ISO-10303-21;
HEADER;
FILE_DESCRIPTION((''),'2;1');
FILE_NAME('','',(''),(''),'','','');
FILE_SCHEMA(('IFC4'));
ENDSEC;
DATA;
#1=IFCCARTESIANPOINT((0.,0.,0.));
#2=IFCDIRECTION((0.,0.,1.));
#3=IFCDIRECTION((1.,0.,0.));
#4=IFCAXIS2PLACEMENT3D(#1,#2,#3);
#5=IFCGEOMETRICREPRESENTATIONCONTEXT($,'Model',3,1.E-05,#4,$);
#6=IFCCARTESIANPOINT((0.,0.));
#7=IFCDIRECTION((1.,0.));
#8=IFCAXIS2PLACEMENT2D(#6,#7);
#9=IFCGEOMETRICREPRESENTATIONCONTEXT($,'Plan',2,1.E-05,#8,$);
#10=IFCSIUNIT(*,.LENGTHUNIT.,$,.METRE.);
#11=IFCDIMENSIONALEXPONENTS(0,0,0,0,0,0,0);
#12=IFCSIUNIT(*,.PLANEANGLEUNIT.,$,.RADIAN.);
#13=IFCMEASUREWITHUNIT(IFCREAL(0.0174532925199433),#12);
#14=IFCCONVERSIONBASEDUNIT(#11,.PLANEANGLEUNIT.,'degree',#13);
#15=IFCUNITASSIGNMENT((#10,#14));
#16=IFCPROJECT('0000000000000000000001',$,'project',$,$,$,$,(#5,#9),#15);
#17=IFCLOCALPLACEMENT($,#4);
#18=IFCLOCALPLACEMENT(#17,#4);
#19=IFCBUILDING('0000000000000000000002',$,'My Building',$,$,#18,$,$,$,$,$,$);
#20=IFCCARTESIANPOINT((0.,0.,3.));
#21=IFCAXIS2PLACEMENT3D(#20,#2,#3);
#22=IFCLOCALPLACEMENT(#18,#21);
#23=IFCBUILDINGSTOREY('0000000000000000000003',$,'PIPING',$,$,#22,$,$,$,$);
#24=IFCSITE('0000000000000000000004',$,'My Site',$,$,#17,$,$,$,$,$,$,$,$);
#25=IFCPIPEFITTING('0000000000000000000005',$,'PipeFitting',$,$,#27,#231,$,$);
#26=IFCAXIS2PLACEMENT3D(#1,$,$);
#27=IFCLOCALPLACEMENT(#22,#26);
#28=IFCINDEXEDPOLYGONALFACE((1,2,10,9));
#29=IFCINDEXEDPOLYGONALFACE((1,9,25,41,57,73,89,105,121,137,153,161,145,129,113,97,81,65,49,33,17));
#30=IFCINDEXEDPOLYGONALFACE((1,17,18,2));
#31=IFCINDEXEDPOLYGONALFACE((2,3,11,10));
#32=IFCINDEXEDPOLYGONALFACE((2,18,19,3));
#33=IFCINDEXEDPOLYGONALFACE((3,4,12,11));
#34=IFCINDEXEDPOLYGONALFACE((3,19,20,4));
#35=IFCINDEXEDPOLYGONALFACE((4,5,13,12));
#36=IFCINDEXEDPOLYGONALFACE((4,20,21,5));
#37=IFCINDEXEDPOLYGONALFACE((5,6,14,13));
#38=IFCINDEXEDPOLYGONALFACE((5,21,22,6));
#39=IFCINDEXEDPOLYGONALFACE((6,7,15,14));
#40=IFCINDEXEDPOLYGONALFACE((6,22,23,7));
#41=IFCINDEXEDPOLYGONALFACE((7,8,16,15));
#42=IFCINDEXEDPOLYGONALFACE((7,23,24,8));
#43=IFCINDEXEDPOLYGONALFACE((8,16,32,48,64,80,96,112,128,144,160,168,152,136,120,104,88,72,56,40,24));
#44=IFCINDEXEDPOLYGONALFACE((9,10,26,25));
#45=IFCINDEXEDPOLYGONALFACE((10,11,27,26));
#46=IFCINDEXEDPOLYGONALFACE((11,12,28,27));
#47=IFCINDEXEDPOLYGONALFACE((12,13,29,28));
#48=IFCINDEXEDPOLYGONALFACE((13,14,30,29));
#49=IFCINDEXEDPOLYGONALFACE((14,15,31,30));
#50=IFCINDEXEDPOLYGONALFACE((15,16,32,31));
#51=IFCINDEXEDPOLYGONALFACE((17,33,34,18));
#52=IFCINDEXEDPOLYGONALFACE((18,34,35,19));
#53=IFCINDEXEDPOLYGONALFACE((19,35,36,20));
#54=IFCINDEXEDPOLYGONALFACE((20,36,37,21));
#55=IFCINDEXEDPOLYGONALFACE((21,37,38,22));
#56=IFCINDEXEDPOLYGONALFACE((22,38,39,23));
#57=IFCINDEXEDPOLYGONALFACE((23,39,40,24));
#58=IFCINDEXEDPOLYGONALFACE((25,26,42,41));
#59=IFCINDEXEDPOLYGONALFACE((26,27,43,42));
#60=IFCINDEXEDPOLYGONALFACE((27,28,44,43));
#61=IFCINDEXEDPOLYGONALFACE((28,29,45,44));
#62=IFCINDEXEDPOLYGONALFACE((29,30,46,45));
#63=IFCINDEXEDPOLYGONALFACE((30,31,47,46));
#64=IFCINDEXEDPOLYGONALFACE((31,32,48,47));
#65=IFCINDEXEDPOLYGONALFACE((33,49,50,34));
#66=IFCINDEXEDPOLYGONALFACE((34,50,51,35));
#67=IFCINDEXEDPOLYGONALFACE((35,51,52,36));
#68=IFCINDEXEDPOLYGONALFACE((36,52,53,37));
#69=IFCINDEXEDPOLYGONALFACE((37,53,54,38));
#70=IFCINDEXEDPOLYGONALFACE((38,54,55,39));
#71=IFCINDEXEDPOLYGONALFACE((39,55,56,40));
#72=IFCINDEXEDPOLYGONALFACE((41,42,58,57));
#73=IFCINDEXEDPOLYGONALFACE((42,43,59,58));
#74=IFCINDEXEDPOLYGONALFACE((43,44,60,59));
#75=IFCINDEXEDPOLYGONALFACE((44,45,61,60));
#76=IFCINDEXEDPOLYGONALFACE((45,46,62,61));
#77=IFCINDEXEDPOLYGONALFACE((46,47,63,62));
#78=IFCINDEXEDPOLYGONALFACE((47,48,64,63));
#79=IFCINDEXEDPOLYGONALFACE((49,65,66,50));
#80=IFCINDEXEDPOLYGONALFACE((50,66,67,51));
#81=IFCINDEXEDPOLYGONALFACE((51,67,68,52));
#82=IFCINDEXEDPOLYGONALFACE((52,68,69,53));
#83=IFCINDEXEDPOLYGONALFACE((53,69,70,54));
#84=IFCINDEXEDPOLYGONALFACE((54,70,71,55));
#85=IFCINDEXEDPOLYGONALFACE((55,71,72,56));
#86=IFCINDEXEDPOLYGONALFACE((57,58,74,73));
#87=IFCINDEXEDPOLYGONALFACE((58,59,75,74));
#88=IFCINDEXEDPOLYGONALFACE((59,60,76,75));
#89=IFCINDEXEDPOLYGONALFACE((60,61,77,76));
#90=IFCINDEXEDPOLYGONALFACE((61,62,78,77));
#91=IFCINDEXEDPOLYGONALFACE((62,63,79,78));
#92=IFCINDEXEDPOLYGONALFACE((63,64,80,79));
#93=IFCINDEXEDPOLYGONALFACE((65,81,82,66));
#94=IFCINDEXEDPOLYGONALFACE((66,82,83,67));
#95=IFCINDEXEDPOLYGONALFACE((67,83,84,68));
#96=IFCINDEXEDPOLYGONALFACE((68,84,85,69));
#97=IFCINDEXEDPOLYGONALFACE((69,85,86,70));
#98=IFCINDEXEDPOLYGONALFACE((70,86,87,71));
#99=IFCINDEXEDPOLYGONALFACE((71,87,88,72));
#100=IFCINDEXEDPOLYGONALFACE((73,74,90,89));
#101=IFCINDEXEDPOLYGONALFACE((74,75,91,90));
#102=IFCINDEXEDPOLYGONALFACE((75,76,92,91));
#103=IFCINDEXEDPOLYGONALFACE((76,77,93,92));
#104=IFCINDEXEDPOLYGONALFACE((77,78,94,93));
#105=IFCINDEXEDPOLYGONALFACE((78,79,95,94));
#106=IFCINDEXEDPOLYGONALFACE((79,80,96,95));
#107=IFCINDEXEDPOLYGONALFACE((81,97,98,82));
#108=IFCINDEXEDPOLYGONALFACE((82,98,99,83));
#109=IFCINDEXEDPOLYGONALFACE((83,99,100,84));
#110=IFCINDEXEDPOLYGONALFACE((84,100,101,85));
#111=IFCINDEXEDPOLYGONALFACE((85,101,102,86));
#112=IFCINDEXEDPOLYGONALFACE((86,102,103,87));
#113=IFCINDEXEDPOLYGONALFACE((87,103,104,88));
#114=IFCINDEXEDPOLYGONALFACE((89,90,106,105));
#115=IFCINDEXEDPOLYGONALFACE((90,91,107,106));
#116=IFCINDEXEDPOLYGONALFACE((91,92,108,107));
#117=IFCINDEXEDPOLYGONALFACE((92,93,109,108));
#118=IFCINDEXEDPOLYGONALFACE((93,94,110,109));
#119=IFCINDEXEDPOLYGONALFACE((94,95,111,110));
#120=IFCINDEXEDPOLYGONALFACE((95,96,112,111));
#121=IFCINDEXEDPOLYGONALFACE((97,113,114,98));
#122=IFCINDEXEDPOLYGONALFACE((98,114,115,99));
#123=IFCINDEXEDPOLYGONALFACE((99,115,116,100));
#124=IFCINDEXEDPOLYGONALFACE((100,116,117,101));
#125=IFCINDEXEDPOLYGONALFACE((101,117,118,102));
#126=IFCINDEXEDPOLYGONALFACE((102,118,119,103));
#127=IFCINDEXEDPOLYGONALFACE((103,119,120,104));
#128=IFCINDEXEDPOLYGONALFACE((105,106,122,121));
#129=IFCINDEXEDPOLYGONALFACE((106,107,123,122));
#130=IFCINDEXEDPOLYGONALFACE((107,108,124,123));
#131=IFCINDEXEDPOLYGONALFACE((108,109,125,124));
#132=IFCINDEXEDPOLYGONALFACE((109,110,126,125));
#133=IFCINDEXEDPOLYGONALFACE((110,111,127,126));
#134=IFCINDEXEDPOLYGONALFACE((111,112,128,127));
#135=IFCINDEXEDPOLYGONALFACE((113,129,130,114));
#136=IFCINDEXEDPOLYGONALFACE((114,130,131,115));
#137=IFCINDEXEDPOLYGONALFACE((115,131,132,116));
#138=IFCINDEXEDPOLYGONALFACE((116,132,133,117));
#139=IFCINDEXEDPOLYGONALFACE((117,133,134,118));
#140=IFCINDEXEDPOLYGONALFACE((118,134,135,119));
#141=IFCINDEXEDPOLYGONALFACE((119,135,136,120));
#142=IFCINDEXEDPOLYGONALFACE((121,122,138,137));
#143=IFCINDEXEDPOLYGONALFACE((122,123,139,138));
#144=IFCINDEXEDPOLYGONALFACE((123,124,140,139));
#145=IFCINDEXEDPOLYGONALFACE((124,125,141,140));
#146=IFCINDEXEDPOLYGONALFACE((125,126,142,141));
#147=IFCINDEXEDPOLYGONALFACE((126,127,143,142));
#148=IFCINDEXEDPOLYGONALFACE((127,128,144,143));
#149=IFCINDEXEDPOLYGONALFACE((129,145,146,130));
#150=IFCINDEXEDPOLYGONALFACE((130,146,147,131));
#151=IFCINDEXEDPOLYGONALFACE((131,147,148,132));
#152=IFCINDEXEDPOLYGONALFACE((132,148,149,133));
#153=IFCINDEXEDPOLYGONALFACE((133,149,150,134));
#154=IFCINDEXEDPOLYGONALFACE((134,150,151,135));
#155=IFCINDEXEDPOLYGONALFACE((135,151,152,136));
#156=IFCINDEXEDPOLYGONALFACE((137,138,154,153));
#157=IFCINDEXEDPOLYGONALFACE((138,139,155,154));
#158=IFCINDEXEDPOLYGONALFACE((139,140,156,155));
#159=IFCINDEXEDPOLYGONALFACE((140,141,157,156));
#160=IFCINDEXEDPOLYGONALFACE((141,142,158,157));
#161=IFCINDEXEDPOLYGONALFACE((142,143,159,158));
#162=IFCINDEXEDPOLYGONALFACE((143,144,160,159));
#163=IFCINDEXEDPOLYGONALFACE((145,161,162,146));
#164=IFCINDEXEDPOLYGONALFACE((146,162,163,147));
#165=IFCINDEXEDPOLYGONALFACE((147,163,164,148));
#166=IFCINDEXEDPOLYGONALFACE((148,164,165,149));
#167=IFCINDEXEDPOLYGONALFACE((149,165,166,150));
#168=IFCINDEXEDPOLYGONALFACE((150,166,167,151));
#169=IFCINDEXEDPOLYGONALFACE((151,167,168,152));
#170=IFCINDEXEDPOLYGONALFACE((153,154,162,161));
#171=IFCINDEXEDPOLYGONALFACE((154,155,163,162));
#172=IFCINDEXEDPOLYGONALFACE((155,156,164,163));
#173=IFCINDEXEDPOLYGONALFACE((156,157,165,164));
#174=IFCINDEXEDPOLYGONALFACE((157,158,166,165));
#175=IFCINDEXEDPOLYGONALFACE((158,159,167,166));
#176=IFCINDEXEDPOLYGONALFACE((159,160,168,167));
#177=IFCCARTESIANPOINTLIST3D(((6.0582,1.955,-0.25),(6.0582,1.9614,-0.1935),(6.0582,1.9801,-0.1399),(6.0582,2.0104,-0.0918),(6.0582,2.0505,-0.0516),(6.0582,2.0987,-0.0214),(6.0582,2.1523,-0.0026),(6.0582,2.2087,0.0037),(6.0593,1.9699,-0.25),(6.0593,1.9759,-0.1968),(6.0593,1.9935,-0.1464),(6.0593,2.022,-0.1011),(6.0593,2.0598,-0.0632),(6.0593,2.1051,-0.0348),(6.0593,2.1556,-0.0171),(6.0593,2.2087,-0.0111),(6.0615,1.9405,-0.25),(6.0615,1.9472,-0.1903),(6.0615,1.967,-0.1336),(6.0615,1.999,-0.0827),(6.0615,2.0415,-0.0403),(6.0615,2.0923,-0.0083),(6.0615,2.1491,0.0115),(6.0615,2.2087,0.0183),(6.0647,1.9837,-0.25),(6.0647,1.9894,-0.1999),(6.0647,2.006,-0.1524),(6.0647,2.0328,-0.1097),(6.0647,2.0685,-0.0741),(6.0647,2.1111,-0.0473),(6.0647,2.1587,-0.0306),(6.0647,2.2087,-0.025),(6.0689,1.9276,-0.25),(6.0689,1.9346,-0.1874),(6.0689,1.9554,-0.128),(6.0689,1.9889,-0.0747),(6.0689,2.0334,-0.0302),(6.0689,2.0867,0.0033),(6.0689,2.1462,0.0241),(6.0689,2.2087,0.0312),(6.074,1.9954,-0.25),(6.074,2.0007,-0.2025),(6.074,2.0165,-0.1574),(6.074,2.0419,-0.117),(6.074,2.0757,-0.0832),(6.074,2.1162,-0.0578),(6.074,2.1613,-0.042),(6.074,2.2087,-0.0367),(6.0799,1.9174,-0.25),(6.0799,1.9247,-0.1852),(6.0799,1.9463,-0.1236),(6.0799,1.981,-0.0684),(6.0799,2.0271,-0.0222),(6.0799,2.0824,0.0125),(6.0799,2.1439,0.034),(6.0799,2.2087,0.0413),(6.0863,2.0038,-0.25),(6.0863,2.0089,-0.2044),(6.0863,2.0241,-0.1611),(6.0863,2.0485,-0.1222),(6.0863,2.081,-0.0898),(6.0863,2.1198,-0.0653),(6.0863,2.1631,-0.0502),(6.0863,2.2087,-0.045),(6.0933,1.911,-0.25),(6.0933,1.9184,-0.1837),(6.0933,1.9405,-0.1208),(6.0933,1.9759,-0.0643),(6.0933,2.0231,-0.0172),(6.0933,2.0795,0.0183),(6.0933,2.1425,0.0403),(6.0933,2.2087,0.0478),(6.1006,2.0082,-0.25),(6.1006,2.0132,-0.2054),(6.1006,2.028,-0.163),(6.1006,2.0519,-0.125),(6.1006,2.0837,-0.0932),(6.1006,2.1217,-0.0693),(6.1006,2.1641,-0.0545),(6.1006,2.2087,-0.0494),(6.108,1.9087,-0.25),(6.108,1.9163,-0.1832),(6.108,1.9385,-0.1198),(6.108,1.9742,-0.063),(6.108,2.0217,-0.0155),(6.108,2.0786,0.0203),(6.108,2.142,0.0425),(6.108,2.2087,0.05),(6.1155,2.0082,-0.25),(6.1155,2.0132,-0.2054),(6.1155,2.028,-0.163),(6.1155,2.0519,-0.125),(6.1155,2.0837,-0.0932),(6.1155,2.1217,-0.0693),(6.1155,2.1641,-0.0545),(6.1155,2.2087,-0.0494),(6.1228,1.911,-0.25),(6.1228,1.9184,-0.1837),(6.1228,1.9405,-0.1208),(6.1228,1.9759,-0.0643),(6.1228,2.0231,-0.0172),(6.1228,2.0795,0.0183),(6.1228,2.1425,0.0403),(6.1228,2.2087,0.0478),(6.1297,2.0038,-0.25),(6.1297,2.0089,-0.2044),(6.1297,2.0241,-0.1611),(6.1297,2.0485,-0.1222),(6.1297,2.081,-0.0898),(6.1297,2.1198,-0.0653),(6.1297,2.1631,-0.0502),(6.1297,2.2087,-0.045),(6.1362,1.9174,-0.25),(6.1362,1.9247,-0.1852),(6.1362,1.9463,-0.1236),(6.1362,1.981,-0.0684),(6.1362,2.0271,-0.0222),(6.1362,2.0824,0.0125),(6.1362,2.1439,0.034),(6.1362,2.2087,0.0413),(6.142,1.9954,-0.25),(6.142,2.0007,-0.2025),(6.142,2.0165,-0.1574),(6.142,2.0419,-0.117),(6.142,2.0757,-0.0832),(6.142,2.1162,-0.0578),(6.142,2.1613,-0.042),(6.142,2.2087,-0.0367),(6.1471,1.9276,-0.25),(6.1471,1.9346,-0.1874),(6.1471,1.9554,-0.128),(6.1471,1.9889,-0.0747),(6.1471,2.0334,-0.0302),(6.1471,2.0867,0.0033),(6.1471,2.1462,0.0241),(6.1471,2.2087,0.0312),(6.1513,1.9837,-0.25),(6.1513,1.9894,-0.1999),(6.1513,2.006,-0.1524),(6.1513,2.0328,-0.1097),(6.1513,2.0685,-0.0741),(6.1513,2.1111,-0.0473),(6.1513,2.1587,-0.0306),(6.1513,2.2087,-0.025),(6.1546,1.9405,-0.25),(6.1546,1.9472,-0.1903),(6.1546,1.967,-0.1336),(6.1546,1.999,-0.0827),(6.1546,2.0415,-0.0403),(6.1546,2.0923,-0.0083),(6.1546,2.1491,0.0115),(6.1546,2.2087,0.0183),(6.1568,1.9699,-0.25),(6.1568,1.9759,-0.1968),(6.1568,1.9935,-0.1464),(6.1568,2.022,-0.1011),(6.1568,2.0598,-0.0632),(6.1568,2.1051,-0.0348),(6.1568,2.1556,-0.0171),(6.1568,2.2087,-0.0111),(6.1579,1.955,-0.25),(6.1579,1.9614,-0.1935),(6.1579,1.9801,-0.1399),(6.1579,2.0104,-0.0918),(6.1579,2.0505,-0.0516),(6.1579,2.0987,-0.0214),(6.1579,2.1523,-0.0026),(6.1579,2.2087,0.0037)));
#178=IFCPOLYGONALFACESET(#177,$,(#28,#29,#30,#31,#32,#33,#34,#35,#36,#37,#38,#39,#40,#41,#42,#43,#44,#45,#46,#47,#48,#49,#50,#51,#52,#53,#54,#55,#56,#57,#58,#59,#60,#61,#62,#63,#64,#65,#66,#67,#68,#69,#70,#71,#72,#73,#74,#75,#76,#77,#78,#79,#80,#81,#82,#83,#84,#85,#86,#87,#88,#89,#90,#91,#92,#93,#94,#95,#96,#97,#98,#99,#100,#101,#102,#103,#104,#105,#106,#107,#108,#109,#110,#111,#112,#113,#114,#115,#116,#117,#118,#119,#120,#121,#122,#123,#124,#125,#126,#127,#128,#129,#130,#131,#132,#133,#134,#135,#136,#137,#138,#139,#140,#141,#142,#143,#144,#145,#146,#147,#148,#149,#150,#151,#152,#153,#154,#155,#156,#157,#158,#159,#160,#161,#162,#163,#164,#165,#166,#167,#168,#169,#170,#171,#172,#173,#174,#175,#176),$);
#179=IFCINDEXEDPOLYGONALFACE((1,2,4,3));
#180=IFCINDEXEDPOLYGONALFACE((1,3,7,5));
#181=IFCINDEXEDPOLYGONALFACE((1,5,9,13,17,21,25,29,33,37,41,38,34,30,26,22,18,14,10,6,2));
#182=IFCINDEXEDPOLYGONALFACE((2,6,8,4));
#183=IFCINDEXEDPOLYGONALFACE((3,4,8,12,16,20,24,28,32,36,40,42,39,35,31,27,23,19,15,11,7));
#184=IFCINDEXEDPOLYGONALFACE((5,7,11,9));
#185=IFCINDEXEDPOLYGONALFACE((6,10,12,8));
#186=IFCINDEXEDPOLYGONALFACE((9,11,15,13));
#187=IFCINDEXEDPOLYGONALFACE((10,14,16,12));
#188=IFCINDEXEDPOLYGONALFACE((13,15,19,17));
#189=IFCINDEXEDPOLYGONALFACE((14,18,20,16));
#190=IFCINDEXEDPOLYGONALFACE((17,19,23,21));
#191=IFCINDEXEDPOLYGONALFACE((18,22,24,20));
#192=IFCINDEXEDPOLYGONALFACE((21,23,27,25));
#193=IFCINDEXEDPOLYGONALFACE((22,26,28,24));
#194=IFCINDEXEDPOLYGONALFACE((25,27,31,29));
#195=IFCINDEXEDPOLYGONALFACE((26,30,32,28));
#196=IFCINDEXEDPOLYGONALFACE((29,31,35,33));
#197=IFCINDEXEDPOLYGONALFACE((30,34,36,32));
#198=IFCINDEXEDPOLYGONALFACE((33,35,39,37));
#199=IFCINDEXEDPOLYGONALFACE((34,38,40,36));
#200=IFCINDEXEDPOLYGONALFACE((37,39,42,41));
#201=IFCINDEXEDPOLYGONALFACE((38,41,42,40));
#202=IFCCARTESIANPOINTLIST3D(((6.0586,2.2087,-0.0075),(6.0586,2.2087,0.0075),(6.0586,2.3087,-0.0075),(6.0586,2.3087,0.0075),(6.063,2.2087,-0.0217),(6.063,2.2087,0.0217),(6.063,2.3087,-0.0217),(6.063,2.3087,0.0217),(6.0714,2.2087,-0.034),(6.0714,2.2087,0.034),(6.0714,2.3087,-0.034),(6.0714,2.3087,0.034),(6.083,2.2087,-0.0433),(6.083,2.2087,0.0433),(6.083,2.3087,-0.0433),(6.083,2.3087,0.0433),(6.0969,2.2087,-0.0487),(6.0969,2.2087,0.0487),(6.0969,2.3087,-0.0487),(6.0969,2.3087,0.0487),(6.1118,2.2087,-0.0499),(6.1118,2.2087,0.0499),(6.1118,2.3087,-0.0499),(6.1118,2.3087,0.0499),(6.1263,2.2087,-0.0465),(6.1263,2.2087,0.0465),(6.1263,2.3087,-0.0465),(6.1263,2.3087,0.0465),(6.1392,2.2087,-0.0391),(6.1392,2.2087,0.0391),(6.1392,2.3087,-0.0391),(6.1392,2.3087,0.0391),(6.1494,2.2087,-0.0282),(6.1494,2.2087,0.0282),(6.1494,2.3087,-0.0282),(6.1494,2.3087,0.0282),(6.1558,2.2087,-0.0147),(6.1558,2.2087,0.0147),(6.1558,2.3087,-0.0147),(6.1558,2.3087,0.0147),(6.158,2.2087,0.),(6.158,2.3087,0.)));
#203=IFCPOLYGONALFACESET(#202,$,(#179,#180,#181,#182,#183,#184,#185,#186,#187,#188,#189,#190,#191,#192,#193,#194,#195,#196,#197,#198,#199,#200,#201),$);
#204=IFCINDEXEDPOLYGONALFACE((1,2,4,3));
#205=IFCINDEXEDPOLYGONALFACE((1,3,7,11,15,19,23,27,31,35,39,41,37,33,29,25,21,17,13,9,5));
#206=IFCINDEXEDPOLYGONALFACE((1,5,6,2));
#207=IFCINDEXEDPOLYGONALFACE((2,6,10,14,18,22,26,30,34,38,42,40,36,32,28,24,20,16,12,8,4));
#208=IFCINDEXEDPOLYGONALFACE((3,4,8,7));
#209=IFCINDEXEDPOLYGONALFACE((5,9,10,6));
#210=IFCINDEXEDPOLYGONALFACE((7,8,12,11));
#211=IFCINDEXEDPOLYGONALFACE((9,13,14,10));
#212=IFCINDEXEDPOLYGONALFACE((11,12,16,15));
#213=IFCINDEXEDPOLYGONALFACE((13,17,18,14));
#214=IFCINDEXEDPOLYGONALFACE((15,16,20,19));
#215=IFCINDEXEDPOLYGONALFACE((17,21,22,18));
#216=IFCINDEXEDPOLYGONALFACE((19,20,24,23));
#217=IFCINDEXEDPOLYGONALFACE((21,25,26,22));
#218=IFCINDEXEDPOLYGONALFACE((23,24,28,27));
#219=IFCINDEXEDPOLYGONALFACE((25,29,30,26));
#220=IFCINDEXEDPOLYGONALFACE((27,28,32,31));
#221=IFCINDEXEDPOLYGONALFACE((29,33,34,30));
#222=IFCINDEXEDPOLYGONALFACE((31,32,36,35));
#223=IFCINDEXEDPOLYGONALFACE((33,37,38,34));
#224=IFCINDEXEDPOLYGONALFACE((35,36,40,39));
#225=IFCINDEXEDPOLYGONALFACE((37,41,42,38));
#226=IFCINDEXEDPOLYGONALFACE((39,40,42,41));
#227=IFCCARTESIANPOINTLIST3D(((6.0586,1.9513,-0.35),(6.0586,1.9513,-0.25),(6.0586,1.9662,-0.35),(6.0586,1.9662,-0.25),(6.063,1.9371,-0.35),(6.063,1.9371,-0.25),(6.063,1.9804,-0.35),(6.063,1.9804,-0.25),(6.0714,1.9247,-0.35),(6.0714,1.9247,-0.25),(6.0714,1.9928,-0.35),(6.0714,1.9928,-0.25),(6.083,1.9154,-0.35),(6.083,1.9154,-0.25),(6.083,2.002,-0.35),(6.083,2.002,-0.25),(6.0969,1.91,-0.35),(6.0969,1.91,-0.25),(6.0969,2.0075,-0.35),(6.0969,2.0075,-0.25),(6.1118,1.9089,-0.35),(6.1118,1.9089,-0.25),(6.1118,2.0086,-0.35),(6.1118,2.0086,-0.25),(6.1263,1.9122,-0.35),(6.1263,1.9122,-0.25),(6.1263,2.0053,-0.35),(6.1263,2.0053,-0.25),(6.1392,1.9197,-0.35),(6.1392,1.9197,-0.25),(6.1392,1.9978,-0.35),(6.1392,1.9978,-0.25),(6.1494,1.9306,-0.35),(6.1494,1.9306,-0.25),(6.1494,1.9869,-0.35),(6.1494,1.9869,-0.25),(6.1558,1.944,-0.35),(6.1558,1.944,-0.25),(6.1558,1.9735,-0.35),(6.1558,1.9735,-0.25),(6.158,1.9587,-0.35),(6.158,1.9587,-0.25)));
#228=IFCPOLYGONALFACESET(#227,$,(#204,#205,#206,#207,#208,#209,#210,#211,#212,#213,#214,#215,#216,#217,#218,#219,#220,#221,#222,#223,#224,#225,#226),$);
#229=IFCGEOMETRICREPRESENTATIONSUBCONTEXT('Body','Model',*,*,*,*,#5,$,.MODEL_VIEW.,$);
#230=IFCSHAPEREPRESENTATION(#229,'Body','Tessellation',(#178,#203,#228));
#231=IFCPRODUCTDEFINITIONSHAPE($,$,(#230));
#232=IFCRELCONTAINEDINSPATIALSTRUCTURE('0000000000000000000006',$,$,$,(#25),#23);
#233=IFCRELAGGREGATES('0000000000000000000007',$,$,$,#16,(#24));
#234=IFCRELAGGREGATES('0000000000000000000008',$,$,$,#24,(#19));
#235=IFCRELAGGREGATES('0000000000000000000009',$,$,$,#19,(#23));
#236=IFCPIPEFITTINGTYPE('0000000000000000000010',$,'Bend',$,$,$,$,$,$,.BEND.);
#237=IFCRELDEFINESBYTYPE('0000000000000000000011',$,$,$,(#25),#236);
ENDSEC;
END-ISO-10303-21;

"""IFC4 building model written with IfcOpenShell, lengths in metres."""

from ifc_helpers import new_model, entity, si_unit, converted_unit, frame, origin_with_axes, origin_2d_with_axis, place, context, subcontext, project, spatial, circle, extrude, source, transform, mapped, type_object, type_shapes, element, save


model = new_model("IFC4")

# Units and contexts
model_context = context("Model", 3, precision=1e-05, world=origin_with_axes())
plan_context = context("Plan", 2, precision=1e-05, world=origin_2d_with_axis())
body_context = subcontext(model_context, "Body", "Model", "MODEL_VIEW")
ifc_project = project(units=[si_unit("LENGTHUNIT", "METRE"), converted_unit("PLANEANGLEUNIT", "degree", entity("IfcReal", 0.0174532925199433), si_unit("PLANEANGLEUNIT", "RADIAN"), dimensions=[0, 0, 0, 0, 0, 0, 0])], contexts=[model_context, plan_context])

# Site, building, storey
site_placement = place(None, origin_with_axes())
site = spatial("IfcSite", under=ifc_project, at=site_placement, Name="My Site")
building_placement = place(site_placement, origin_with_axes())
building = spatial("IfcBuilding", under=site, at=building_placement, Name="My Building")
storey_placement = place(building_placement, frame((0.0, 0.0, 3.0), z_axis=(0.0, 0.0, 1.0), x_axis=(1.0, 0.0, 0.0)))
storey = spatial("IfcBuildingStorey", under=building, at=storey_placement, Name="PIPING")

# Pipe fitting
pipe_fitting_type = type_object("IfcPipeFittingType", Name="Bend", PredefinedType="BEND")
shared_shape = source(origin_with_axes(), body_context, "Body", "SolidModel", [
    entity("IfcSweptDiskSolid", entity("IfcIndexedPolyCurve", entity("IfcCartesianPointList3D", [[0.0, 0.0, 0.1], [0.0, -0.0732, 0.2768], [0.0, -0.25, 0.35]]), [entity("IfcArcIndex", [1, 2, 3])]), 0.05),
    extrude(circle(Radius=0.05), origin_with_axes(), (0.0, 0.0, 1.0), 0.1),
    extrude(circle(Radius=0.05), frame((0.0, -0.25, 0.35), z_axis=(0.0, -1.0, 0.0), x_axis=(1.0, 0.0, 0.0)), (0.0, 0.0, 1.0), 0.1),
])
type_shapes(pipe_fitting_type, [shared_shape])
for number, where, z_axis, x_axis, name in (
    (1, (6.108, 2.3087, 0.0), (0.0, -1.0, 0.0), (1.0, 0.0, 0.0), "PipeFitting"),
):
    element("IfcPipeFitting", number, at=place(storey_placement, frame(where, z_axis=z_axis, x_axis=x_axis)), inside=storey, type_object=pipe_fitting_type, Name=name, context=body_context, shape_type="MappedRepresentation", body=[
        mapped(shared_shape, transform((0.0, 0.0, 0.0), x_axis=(1.0, 0.0, 0.0), y_axis=(0.0, 1.0, 0.0), z_axis=(0.0, 0.0, 1.0), scale=1.0)),
    ])

save(model, "model.ifc")
